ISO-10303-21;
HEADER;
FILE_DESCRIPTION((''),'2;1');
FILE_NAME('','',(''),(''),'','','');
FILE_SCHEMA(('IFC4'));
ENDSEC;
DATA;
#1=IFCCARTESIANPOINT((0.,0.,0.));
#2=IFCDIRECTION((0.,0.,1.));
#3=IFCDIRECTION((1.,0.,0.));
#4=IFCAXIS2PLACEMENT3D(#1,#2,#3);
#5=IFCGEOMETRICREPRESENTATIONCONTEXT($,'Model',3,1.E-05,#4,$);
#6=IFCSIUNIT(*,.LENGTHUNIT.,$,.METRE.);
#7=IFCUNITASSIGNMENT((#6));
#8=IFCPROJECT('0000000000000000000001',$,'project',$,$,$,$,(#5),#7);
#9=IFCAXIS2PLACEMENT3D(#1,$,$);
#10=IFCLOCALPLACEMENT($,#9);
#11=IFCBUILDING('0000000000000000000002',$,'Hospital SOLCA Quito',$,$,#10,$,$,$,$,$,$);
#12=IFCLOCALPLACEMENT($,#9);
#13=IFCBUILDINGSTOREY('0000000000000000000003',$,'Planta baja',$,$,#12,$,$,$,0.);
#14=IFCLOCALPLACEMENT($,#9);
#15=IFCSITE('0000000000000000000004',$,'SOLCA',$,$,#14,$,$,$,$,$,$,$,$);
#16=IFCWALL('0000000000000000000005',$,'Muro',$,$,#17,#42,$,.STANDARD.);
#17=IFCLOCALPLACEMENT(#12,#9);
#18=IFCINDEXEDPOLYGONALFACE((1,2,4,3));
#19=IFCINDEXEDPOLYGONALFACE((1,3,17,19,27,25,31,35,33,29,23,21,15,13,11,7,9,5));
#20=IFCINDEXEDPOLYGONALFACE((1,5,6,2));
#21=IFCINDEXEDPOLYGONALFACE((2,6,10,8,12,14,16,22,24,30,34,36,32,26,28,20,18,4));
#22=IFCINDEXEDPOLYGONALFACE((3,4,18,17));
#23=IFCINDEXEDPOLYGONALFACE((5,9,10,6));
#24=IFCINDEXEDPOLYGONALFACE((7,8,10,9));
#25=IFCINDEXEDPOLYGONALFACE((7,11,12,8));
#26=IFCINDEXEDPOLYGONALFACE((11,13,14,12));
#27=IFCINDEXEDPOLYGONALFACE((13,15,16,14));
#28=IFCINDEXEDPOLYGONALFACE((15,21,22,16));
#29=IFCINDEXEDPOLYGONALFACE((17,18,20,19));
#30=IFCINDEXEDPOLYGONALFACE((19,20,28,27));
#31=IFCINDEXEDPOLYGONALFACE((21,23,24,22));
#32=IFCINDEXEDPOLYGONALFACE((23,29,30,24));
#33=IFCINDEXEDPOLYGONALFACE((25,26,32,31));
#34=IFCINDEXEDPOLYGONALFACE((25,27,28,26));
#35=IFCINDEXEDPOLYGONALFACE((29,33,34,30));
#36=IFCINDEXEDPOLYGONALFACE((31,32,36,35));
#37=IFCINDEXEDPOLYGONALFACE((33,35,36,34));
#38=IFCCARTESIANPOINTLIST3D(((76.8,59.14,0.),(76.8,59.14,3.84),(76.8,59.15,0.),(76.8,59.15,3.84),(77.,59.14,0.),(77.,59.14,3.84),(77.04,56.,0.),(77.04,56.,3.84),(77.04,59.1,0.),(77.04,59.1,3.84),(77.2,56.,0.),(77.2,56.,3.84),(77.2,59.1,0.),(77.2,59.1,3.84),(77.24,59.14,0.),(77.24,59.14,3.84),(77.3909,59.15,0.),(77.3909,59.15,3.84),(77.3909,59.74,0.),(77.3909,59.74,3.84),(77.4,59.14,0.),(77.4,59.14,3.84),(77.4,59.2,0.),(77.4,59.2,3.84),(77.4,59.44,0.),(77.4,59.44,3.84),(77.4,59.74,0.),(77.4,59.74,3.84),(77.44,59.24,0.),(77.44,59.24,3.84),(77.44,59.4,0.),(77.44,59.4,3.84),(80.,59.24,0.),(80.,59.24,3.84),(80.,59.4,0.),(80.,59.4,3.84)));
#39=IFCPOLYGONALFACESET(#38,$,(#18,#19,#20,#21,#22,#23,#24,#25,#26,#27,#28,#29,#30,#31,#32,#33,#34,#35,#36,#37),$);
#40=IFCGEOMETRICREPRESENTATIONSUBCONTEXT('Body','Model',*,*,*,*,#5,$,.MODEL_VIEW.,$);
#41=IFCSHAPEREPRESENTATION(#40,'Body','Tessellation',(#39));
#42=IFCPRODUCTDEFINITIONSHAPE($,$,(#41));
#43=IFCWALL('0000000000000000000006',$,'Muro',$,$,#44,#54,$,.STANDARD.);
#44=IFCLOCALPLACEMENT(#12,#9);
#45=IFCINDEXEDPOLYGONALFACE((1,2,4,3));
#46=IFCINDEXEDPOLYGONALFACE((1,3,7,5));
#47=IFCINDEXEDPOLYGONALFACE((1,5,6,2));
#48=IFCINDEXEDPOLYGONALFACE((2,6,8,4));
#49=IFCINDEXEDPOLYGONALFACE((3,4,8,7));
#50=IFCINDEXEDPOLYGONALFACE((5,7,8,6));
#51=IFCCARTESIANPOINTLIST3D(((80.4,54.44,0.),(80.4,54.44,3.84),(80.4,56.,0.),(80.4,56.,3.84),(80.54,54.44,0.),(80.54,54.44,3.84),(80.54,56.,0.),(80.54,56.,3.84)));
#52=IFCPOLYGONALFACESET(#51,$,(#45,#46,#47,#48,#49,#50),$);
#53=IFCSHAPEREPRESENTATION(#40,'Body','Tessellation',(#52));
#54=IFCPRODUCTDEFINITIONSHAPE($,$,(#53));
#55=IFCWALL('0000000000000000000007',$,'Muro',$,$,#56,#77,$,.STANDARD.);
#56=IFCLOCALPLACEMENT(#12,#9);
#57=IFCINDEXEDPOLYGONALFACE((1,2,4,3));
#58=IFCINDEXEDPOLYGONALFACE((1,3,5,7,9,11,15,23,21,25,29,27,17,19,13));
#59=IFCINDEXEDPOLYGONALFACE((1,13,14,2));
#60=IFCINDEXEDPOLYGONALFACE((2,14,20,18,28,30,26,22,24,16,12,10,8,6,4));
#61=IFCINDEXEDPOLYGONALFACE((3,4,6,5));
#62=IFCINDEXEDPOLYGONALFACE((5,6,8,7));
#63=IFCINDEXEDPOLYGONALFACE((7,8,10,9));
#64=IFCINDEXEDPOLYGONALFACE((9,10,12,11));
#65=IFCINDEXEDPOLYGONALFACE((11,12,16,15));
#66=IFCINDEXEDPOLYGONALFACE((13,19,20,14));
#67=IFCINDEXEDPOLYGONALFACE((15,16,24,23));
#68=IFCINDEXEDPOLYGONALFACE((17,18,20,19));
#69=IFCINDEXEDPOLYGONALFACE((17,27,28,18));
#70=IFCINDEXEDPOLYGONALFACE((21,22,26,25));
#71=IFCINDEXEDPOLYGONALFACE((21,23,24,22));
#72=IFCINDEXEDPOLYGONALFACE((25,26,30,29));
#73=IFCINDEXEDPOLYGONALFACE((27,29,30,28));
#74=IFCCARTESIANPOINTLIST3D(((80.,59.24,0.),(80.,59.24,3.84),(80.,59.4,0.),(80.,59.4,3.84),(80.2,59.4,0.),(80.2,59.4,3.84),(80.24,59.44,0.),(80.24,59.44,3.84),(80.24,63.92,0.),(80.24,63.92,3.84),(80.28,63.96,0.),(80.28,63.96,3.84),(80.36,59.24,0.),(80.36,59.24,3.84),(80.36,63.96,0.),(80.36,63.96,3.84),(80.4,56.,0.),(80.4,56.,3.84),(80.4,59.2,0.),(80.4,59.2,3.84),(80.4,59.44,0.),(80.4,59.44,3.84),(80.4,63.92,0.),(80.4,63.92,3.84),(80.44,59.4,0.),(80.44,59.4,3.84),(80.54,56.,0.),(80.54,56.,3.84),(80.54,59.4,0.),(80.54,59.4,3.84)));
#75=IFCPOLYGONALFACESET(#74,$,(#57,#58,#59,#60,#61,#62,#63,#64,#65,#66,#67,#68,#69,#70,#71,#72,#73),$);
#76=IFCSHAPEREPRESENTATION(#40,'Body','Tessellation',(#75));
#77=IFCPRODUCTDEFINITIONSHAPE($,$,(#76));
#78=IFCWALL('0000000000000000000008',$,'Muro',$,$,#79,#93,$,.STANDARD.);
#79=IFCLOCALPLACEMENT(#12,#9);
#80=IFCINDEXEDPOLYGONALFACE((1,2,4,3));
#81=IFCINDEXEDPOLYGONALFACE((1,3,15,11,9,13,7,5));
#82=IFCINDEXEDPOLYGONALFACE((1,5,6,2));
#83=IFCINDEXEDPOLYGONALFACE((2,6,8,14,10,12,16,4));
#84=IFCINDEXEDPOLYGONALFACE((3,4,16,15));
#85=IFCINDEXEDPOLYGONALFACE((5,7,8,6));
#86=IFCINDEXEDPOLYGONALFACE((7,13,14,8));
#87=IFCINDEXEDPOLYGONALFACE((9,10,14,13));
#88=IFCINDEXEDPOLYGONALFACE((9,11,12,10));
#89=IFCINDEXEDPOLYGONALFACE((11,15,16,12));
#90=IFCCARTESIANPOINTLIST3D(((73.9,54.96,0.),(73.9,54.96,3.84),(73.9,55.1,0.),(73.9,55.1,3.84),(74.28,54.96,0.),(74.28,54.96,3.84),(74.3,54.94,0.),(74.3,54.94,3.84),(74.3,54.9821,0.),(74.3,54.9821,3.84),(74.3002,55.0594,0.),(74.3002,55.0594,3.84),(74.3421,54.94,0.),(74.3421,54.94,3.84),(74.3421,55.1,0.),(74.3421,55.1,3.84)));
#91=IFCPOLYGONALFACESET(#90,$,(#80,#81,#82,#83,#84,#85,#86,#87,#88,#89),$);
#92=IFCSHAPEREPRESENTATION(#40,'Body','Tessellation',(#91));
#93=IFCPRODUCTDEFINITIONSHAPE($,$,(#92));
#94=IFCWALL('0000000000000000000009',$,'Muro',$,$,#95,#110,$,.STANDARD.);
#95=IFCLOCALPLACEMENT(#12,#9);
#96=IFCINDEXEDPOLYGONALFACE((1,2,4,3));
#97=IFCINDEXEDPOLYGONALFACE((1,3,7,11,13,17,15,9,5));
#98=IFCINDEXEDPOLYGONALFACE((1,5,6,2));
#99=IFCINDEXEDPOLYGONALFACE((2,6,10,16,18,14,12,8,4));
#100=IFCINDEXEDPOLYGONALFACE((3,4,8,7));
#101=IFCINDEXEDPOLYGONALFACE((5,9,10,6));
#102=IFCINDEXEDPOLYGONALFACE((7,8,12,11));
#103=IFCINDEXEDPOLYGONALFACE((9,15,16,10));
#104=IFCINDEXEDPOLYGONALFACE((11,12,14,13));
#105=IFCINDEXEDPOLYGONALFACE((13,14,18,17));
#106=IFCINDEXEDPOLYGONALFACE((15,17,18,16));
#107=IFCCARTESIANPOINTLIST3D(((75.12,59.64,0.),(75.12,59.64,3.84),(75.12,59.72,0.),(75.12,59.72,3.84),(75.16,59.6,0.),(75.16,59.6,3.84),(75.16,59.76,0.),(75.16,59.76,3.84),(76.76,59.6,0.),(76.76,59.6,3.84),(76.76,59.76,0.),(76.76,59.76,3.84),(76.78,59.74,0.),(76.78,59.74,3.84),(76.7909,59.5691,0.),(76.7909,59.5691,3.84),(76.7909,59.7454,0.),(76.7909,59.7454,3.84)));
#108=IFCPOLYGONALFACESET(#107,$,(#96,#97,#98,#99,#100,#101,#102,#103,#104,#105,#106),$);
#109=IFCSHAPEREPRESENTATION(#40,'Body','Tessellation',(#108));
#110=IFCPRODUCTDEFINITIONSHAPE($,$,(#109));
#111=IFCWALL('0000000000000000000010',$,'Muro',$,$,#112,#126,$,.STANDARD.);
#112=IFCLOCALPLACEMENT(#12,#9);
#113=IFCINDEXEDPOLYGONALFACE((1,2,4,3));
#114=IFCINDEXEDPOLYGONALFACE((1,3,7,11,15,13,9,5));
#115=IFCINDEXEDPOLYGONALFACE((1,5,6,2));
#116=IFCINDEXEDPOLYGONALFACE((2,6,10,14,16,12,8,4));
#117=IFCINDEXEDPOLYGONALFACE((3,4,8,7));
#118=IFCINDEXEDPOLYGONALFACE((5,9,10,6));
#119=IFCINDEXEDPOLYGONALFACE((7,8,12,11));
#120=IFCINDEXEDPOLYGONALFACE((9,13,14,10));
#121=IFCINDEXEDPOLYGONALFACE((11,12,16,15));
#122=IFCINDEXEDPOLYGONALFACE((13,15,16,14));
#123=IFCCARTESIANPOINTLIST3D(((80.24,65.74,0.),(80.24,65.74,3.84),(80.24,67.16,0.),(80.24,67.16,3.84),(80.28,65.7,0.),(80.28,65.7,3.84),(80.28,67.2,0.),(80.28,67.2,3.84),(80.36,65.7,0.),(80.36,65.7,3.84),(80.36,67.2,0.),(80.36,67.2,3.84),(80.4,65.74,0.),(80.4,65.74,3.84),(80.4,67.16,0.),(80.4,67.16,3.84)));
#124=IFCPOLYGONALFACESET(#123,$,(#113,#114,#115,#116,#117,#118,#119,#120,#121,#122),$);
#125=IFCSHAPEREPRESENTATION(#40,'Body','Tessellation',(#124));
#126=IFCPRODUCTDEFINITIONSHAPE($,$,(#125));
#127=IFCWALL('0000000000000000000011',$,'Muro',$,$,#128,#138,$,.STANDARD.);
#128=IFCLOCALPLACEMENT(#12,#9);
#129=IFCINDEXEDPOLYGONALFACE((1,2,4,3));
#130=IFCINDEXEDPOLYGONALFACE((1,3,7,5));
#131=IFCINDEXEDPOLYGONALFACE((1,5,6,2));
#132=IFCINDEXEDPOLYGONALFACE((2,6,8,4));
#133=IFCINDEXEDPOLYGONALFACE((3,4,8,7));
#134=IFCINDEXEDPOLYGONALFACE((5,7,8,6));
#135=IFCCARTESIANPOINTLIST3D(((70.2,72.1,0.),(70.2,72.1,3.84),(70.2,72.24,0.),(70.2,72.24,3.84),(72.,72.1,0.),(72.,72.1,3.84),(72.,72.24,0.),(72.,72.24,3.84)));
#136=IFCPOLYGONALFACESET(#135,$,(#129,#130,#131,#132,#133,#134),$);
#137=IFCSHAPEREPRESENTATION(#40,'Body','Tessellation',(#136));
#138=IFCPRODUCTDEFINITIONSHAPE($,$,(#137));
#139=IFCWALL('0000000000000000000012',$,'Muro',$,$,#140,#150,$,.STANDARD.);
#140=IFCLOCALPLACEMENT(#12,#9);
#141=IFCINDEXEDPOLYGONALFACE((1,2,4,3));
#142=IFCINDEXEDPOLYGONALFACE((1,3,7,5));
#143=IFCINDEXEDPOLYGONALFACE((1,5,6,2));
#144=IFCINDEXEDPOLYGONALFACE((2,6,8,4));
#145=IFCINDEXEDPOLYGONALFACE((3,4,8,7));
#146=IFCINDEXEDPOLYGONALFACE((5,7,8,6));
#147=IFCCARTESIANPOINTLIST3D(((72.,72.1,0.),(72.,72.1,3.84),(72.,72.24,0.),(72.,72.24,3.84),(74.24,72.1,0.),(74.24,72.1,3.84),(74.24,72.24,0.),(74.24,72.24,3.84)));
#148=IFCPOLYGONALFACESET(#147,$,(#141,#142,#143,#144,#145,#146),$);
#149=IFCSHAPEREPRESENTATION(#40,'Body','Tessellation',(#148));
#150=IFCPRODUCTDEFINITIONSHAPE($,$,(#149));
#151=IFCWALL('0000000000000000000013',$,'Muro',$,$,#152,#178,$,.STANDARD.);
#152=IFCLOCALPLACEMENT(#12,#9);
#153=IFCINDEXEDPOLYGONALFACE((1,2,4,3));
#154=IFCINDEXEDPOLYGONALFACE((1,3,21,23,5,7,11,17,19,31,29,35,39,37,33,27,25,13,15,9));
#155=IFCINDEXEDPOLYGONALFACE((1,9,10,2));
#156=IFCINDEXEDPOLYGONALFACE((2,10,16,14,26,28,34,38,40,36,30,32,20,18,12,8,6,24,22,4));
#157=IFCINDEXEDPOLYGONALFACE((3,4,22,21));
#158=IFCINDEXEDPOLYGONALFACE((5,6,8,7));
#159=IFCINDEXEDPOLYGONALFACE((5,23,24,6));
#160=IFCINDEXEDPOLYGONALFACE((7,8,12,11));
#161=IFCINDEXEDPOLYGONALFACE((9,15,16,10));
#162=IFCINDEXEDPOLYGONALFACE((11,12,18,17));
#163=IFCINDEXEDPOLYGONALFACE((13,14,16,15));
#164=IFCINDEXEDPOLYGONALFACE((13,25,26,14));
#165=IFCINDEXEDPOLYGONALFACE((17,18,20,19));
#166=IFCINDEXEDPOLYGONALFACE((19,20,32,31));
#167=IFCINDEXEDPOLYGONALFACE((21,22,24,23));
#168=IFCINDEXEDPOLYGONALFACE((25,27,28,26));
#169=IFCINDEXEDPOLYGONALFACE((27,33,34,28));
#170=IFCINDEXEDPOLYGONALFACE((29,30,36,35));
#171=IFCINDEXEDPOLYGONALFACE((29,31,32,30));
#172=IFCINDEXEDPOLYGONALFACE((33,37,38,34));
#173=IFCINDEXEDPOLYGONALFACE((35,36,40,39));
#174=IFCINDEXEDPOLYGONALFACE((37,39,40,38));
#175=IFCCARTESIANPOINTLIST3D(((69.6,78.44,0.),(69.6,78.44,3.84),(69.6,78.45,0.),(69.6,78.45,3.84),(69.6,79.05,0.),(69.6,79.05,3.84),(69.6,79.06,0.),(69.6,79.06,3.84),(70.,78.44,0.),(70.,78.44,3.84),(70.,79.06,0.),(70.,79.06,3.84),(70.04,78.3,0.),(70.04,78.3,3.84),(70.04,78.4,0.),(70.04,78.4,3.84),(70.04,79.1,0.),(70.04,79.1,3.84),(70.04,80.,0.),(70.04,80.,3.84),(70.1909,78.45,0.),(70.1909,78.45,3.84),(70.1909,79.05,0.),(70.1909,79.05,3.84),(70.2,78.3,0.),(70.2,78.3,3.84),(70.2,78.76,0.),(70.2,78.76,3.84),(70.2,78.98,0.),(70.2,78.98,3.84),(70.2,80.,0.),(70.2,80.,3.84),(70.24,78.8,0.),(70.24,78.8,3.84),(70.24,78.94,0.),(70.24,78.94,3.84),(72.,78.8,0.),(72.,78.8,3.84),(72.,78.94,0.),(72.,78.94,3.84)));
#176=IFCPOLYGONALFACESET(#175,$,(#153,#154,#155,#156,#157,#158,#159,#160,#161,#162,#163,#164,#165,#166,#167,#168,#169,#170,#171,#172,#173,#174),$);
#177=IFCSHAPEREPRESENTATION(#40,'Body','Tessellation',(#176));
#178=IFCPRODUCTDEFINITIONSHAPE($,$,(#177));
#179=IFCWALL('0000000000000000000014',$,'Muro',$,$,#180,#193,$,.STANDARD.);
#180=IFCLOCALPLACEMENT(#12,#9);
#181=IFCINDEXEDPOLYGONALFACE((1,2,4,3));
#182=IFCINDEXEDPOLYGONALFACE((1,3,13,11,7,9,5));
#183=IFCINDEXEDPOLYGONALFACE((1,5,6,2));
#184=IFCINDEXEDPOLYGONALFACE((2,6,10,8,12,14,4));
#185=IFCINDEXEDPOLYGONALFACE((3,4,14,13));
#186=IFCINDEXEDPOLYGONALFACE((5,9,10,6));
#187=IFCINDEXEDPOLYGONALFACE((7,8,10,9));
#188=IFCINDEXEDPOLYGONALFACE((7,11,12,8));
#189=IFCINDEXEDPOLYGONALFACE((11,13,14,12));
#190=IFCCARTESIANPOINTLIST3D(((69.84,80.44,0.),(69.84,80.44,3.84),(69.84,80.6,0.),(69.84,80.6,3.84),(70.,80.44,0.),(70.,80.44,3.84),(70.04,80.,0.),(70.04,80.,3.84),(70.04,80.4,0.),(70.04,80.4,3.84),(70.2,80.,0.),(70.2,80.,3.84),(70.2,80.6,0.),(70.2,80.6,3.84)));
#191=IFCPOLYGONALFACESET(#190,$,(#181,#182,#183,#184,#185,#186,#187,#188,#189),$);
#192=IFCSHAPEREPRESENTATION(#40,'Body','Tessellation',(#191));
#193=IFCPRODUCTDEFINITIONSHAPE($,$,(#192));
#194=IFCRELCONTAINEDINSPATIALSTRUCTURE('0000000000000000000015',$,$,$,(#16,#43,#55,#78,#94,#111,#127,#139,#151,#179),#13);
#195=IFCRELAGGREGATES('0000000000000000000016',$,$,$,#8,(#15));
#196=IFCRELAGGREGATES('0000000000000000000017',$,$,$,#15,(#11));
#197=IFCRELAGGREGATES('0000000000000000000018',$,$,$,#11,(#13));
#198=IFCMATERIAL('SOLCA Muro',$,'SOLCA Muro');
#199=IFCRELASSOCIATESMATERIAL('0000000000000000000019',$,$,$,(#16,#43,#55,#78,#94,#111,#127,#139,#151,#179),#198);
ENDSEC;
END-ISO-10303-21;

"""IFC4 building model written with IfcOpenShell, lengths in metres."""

from ifc_helpers import new_model, si_unit, origin, origin_with_axes, place, context, subcontext, project, spatial, polyline, outline, extrude, material, element, save


model = new_model("IFC4")

# Units and contexts
model_context = context("Model", 3, precision=1e-05, world=origin_with_axes())
body_context = subcontext(model_context, "Body", "Model", "MODEL_VIEW")
ifc_project = project(units=[si_unit("LENGTHUNIT", "METRE")], contexts=[model_context])

# Site, building, storey
site_placement = place(None, origin())
site = spatial("IfcSite", under=ifc_project, at=site_placement, Name="SOLCA")
building_placement = place(None, origin())
building = spatial("IfcBuilding", under=site, at=building_placement, Name="Hospital SOLCA Quito")
storey_placement = place(None, origin())
storey = spatial("IfcBuildingStorey", under=building, at=storey_placement, Name="Planta baja", Elevation=0.0)

# Walls
ifc_material = material(Name="SOLCA Muro", Category="SOLCA Muro")
wall_1_placement = place(storey_placement, origin_with_axes())
element("IfcWall", 1, at=wall_1_placement, inside=storey, material=ifc_material, Name="Muro", PredefinedType="STANDARD", context=body_context, shape_type="SweptSolid", body=[
    extrude(outline(polyline([(77.04, 59.1), (77.0, 59.14), (76.8, 59.14), (76.8, 59.15), (77.3909, 59.15), (77.3909, 59.74), (77.4, 59.74), (77.4, 59.44), (77.44, 59.4), (80.0, 59.4), (80.0, 59.24), (77.44, 59.24), (77.4, 59.2), (77.4, 59.14), (77.24, 59.14), (77.2, 59.1), (77.2, 56.0), (77.04, 56.0), (77.04, 59.1)])), origin_with_axes(), (0.0, 0.0, 1.0), 3.84),
])
wall_2_placement = place(storey_placement, origin_with_axes())
element("IfcWall", 2, at=wall_2_placement, inside=storey, material=ifc_material, Name="Muro", PredefinedType="STANDARD", context=body_context, shape_type="SweptSolid", body=[
    extrude(outline(polyline([(80.54, 54.44), (80.4, 54.44), (80.4, 56.0), (80.54, 56.0), (80.54, 54.44)])), origin_with_axes(), (0.0, 0.0, 1.0), 3.84),
])
wall_3_placement = place(storey_placement, origin_with_axes())
element("IfcWall", 3, at=wall_3_placement, inside=storey, material=ifc_material, Name="Muro", PredefinedType="STANDARD", context=body_context, shape_type="SweptSolid", body=[
    extrude(outline(polyline([(80.2, 59.4), (80.24, 59.44), (80.24, 63.92), (80.28, 63.96), (80.36, 63.96), (80.4, 63.92), (80.4, 59.44), (80.44, 59.4), (80.54, 59.4), (80.54, 56.0), (80.4, 56.0), (80.4, 59.2), (80.36, 59.24), (80.0, 59.24), (80.0, 59.4), (80.2, 59.4)])), origin_with_axes(), (0.0, 0.0, 1.0), 3.84),
])
wall_4_placement = place(storey_placement, origin_with_axes())
element("IfcWall", 4, at=wall_4_placement, inside=storey, material=ifc_material, Name="Muro", PredefinedType="STANDARD", context=body_context, shape_type="SweptSolid", body=[
    extrude(outline(polyline([(74.3421, 55.1), (74.3002, 55.0594), (74.3, 54.9821), (74.3421, 54.94), (74.3, 54.94), (74.28, 54.96), (73.9, 54.96), (73.9, 55.1), (74.3421, 55.1)])), origin_with_axes(), (0.0, 0.0, 1.0), 3.84),
])
wall_5_placement = place(storey_placement, origin_with_axes())
element("IfcWall", 5, at=wall_5_placement, inside=storey, material=ifc_material, Name="Muro", PredefinedType="STANDARD", context=body_context, shape_type="SweptSolid", body=[
    extrude(outline(polyline([(75.12, 59.64), (75.12, 59.72), (75.16, 59.76), (76.76, 59.76), (76.78, 59.74), (76.7909, 59.7454), (76.7909, 59.5691), (76.76, 59.6), (75.16, 59.6), (75.12, 59.64)])), origin_with_axes(), (0.0, 0.0, 1.0), 3.84),
])
wall_6_placement = place(storey_placement, origin_with_axes())
element("IfcWall", 6, at=wall_6_placement, inside=storey, material=ifc_material, Name="Muro", PredefinedType="STANDARD", context=body_context, shape_type="SweptSolid", body=[
    extrude(outline(polyline([(80.4, 65.74), (80.36, 65.7), (80.28, 65.7), (80.24, 65.74), (80.24, 67.16), (80.28, 67.2), (80.36, 67.2), (80.4, 67.16), (80.4, 65.74)])), origin_with_axes(), (0.0, 0.0, 1.0), 3.84),
])
wall_7_placement = place(storey_placement, origin_with_axes())
element("IfcWall", 7, at=wall_7_placement, inside=storey, material=ifc_material, Name="Muro", PredefinedType="STANDARD", context=body_context, shape_type="SweptSolid", body=[
    extrude(outline(polyline([(70.2, 72.1), (70.2, 72.24), (72.0, 72.24), (72.0, 72.1), (70.2, 72.1)])), origin_with_axes(), (0.0, 0.0, 1.0), 3.84),
])
wall_8_placement = place(storey_placement, origin_with_axes())
element("IfcWall", 8, at=wall_8_placement, inside=storey, material=ifc_material, Name="Muro", PredefinedType="STANDARD", context=body_context, shape_type="SweptSolid", body=[
    extrude(outline(polyline([(74.24, 72.1), (72.0, 72.1), (72.0, 72.24), (74.24, 72.24), (74.24, 72.1)])), origin_with_axes(), (0.0, 0.0, 1.0), 3.84),
])
wall_9_placement = place(storey_placement, origin_with_axes())
element("IfcWall", 9, at=wall_9_placement, inside=storey, material=ifc_material, Name="Muro", PredefinedType="STANDARD", context=body_context, shape_type="SweptSolid", body=[
    extrude(outline(polyline([(70.24, 78.8), (70.2, 78.76), (70.2, 78.3), (70.04, 78.3), (70.04, 78.4), (70.0, 78.44), (69.6, 78.44), (69.6, 78.45), (70.1909, 78.45), (70.1909, 79.05), (69.6, 79.05), (69.6, 79.06), (70.0, 79.06), (70.04, 79.1), (70.04, 80.0), (70.2, 80.0), (70.2, 78.98), (70.24, 78.94), (72.0, 78.94), (72.0, 78.8), (70.24, 78.8)])), origin_with_axes(), (0.0, 0.0, 1.0), 3.84),
])
wall_10_placement = place(storey_placement, origin_with_axes())
element("IfcWall", 10, at=wall_10_placement, inside=storey, material=ifc_material, Name="Muro", PredefinedType="STANDARD", context=body_context, shape_type="SweptSolid", body=[
    extrude(outline(polyline([(70.04, 80.4), (70.0, 80.44), (69.84, 80.44), (69.84, 80.6), (70.2, 80.6), (70.2, 80.0), (70.04, 80.0), (70.04, 80.4)])), origin_with_axes(), (0.0, 0.0, 1.0), 3.84),
])

save(model, "model.ifc")
